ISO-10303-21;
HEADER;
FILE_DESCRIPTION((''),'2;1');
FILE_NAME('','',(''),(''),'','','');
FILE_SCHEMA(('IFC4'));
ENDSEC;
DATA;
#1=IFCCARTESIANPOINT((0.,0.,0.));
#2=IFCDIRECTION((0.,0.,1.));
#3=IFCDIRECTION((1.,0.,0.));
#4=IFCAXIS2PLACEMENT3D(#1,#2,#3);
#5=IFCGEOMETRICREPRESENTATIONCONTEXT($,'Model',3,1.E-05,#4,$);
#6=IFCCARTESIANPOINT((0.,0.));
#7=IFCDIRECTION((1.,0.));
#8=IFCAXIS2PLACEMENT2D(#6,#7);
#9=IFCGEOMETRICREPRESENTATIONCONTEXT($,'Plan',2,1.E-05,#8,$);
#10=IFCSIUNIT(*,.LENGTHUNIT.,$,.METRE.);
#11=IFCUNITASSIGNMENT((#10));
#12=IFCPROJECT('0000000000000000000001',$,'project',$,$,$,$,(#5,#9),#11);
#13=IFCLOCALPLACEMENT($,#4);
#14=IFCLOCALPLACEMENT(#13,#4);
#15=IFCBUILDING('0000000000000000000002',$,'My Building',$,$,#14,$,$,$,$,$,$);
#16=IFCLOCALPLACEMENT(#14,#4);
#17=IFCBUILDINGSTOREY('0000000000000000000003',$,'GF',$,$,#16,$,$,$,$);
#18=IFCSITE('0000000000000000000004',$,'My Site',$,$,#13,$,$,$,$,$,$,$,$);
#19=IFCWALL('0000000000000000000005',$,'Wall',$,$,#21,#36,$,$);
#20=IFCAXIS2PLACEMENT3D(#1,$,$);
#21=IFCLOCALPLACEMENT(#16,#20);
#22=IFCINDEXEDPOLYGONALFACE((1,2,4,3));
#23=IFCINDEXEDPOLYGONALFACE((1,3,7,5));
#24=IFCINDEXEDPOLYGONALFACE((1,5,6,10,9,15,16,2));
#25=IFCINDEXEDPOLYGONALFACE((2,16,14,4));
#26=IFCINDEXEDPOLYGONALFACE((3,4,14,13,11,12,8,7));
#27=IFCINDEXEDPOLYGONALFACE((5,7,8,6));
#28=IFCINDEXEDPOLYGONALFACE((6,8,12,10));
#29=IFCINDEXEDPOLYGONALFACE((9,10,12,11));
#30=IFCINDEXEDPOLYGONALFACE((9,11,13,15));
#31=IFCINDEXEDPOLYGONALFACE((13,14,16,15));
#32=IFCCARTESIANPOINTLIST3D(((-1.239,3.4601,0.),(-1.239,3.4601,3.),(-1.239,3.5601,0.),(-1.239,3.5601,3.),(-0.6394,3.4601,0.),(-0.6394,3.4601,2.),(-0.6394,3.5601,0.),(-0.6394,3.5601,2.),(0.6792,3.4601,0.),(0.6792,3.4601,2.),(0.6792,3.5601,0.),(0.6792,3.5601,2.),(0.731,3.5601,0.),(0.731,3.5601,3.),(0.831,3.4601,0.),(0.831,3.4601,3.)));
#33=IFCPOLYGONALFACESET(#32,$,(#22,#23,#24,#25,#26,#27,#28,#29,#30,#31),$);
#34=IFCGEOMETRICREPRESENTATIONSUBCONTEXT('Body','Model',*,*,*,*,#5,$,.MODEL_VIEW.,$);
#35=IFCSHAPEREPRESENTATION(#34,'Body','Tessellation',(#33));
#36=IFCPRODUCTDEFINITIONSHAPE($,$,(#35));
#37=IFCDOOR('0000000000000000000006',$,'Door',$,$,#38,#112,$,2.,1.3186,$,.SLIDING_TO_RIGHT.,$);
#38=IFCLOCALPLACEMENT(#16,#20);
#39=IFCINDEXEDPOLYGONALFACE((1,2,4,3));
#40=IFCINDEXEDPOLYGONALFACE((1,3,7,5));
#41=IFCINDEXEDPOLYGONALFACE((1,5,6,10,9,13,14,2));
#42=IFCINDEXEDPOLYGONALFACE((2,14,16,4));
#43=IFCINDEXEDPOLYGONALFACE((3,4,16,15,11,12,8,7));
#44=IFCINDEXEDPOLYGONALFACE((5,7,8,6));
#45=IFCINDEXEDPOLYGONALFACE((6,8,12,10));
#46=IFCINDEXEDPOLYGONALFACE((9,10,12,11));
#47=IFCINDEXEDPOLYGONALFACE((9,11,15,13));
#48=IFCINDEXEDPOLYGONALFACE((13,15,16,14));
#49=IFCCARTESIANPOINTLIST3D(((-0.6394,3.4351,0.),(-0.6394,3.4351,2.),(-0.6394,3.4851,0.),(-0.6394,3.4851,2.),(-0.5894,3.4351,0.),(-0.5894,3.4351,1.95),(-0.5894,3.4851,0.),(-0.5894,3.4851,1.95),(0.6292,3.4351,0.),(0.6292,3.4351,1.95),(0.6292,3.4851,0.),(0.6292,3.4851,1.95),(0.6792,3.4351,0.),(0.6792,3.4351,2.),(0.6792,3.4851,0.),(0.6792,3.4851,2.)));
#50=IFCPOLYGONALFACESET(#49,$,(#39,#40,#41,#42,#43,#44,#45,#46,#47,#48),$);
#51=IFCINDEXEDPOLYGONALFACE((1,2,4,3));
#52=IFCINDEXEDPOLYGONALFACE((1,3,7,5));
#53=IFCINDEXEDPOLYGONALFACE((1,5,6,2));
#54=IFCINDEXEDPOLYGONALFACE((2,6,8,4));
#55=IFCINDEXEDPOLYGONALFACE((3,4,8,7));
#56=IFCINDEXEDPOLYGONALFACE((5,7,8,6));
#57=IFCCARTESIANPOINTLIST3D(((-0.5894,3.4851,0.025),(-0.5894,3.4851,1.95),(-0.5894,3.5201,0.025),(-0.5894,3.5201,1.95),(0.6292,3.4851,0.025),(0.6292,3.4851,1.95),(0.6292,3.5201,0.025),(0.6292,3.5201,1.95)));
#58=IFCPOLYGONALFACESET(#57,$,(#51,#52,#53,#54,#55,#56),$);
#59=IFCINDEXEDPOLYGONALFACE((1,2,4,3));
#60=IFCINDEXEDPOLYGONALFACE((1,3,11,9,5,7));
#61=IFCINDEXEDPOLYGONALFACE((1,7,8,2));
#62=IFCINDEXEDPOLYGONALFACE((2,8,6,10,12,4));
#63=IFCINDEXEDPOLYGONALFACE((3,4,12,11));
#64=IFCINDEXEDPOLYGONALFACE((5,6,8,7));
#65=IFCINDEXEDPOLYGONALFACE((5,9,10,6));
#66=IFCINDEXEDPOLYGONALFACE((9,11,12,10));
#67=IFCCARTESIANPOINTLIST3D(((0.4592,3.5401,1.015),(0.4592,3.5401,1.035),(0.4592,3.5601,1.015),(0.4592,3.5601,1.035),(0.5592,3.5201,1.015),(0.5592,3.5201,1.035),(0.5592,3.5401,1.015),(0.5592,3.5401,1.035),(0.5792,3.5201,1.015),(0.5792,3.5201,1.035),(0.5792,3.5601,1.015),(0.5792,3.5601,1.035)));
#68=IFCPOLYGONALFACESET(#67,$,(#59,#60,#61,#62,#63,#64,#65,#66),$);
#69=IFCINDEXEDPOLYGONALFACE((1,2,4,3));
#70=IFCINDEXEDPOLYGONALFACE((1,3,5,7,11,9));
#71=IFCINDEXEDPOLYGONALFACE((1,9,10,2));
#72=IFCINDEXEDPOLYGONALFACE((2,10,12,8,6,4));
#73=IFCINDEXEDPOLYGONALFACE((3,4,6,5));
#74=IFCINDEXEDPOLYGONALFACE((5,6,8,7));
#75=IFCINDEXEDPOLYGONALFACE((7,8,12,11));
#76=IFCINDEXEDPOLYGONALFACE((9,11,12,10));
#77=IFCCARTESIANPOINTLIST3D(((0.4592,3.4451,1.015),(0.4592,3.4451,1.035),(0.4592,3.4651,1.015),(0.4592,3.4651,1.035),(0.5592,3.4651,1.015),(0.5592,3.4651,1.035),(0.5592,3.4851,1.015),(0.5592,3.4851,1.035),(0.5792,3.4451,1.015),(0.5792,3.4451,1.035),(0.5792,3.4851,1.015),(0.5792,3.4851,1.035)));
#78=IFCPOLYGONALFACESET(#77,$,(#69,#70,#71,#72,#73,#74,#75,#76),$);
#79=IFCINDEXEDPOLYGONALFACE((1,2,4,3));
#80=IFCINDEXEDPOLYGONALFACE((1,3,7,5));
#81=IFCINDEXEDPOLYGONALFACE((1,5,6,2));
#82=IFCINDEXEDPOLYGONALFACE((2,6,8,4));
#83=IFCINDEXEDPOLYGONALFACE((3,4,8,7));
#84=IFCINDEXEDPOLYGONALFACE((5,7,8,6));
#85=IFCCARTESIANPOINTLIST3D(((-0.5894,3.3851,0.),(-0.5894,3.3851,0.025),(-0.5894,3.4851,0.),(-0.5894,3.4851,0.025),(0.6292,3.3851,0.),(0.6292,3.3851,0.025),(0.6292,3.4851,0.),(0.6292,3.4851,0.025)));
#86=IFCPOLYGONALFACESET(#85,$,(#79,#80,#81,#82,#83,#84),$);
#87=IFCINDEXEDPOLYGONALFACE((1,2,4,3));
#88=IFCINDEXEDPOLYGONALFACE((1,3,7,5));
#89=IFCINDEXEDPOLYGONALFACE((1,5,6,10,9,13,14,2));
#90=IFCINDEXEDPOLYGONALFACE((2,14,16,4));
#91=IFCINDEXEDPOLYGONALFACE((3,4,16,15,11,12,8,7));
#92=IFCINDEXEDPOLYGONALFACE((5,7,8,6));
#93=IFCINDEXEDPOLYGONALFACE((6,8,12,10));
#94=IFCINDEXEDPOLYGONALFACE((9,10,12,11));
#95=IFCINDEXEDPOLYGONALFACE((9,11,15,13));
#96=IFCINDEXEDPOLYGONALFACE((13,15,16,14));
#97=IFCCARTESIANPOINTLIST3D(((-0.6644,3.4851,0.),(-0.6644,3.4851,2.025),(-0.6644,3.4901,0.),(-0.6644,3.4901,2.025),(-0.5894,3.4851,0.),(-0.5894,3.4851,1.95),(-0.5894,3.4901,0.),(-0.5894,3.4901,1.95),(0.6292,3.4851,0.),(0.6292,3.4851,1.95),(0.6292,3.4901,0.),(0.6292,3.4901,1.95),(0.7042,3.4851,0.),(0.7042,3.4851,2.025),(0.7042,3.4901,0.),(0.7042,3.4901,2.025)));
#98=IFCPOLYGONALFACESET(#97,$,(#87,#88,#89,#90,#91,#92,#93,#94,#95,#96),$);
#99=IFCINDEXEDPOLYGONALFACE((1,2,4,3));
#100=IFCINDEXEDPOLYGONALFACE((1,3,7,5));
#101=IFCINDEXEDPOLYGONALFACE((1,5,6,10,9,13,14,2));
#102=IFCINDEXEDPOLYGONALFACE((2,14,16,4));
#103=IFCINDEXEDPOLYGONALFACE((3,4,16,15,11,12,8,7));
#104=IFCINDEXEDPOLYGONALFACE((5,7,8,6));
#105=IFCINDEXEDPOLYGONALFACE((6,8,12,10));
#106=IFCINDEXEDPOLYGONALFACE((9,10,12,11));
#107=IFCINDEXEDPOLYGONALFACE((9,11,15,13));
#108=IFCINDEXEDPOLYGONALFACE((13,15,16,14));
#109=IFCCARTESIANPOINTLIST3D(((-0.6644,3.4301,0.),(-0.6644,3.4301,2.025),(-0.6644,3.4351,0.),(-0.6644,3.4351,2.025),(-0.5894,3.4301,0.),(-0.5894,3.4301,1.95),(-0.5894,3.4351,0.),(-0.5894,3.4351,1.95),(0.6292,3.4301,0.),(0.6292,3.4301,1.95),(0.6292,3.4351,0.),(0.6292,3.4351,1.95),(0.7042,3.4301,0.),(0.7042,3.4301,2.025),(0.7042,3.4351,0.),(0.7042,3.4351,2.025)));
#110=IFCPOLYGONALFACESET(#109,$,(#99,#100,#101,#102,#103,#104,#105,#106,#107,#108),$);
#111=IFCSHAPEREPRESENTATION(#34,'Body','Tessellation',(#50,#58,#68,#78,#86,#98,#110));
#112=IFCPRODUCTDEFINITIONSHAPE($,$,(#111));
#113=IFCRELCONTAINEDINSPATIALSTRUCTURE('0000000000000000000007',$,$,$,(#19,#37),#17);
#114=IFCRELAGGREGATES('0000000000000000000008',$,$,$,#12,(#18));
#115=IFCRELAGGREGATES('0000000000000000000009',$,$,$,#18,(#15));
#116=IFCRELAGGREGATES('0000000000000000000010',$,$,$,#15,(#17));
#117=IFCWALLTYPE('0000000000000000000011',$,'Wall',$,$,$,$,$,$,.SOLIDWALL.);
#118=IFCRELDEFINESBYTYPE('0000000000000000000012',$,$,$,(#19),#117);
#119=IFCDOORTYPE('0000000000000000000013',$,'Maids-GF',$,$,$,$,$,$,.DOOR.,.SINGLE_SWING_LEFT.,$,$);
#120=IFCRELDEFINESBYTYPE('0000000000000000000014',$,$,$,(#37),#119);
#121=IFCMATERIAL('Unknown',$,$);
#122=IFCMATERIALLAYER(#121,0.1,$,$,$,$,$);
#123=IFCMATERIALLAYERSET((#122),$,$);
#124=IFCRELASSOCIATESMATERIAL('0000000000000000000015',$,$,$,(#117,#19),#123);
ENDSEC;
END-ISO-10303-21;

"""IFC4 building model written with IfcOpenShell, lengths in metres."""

from ifc_helpers import new_model, entity, si_unit, frame, origin_with_axes, origin_2d_with_axis, place, context, subcontext, project, spatial, line, indexed_curve, outline, extrude, shape, source, transform, mapped, material, layer, layer_set, layer_usage, type_object, type_shapes, element, fill, save


model = new_model("IFC4")

# Units and contexts
model_context = context("Model", 3, precision=1e-05, world=origin_with_axes())
plan_context = context("Plan", 2, precision=1e-05, world=origin_2d_with_axis())
body_context_1 = subcontext(model_context, "Body", "Model", "MODEL_VIEW")
body_context_2 = subcontext(plan_context, "Body", "Plan", "PLAN_VIEW")
ifc_project = project(units=[si_unit("LENGTHUNIT", "METRE")], contexts=[model_context, plan_context])

# Site, building, storey
site_placement = place(None, origin_with_axes())
site = spatial("IfcSite", under=ifc_project, at=site_placement, Name="My Site")
building_placement = place(site_placement, origin_with_axes())
building = spatial("IfcBuilding", under=site, at=building_placement, Name="My Building")
storey_placement = place(building_placement, origin_with_axes())
storey = spatial("IfcBuildingStorey", under=building, at=storey_placement, Name="GF")

# Shared definitions
ifc_material_1 = material(Name="Unknown")

# Shared definitions
ifc_layer_1 = layer(ifc_material_1, 0.1)
ifc_layer_set_1 = layer_set([ifc_layer_1])
wall_type = type_object("IfcWallType", Name="Wall", PredefinedType="SOLIDWALL", material=ifc_layer_set_1)

# Wall, opening, door
ifc_layer_usage_1 = layer_usage(ifc_layer_set_1, "AXIS2", "POSITIVE", 0.0)
wall_1_placement = place(storey_placement, frame((0.731, 3.5601, 0.0), z_axis=(0.0, 0.0, 1.0), x_axis=(-1.0, 0.0, 0.0)))
wall_1 = element("IfcWall", 1, at=wall_1_placement, inside=storey, type_object=wall_type, material=ifc_layer_usage_1, Name="Wall", context=body_context_1, shape_type="SweptSolid", body=[
    extrude(outline(indexed_curve([(0.0, 0.0), (-0.1, 0.1), (1.97, 0.1), (1.97, 0.0)], segments=[line(1, 2, 3, 4, 1)])), origin_with_axes(), (0.0, 0.0, 1.0), 3.0),
])
shared_shape_1 = source(origin_with_axes(), body_context_1, "Body", "SweptSolid", [
    extrude(outline(indexed_curve([(0.0, 0.0), (1.3186, 0.0), (1.3186, 2.0), (0.0, 2.0)], segments=[line(1, 2, 3, 4, 1)])), frame((0.0, -0.6, 0.0), z_axis=(0.0, -1.0, 0.0), x_axis=(1.0, 0.0, 0.0)), (0.0, 0.0, -1.0), 1.2),
])
opening_1_placement = place(wall_1_placement, frame((0.0518, 0.075, 0.0), z_axis=(0.0, 0.0, 1.0), x_axis=(1.0, 0.0, 0.0)))
opening_1 = element("IfcOpeningElement", 2, at=opening_1_placement, cuts=wall_1, PredefinedType="OPENING", context=body_context_1, shape_type="MappedRepresentation", body=[
    mapped(shared_shape_1, transform((0.0, 0.0, 0.0), x_axis=(1.0, 0.0, 0.0), y_axis=(0.0, 1.0, 0.0), z_axis=(0.0, 0.0, 1.0), scale=1.0)),
])
door_type_1 = type_object("IfcDoorType", Name="Maids-GF", OperationType="SINGLE_SWING_LEFT", PredefinedType="DOOR")
shared_shape_2 = source(origin_with_axes(), body_context_1, "Body", "SweptSolid", [
    extrude(outline(indexed_curve([(0.0, 0.0), (0.0, 2.0), (1.3186, 2.0), (1.3186, 0.0), (1.2686, 0.0), (1.2686, 1.95), (0.05, 1.95), (0.05, 0.0)], segments=[line(1, 2, 3, 4, 5, 6, 7, 8, 1)])), frame((0.0, 0.0, 0.0), z_axis=(0.0, -1.0, 0.0), x_axis=(1.0, 0.0, 0.0)), (0.0, 0.0, -1.0), 0.05),
    extrude(outline(indexed_curve([(0.0, 0.0), (1.2186, 0.0), (1.2186, 0.035), (0.0, 0.035)], segments=[line(1, 2, 3, 4, 1)])), frame((0.05, -0.035, 0.025), z_axis=(0.0, 0.0, 1.0), x_axis=(1.0, 0.0, 0.0)), (0.0, 0.0, 1.0), 1.925),
    extrude(outline(indexed_curve([(0.0, 0.0), (0.0, -0.04), (0.12, -0.04), (0.12, -0.02), (0.02, -0.02), (0.02, 0.0)], segments=[line(1, 2, 3, 4, 5, 6, 1)])), frame((0.1, -0.035, 1.015), z_axis=(0.0, 0.0, 1.0), x_axis=(1.0, 0.0, 0.0)), (0.0, 0.0, 1.0), 0.02),
    extrude(outline(indexed_curve([(0.0, 0.0), (0.0, 0.04), (0.12, 0.04), (0.12, 0.02), (0.02, 0.02), (0.02, 0.0)], segments=[line(1, 2, 3, 4, 5, 6, 1)])), frame((0.1, 0.0, 1.015), z_axis=(0.0, 0.0, 1.0), x_axis=(1.0, 0.0, 0.0)), (0.0, 0.0, 1.0), 0.02),
    extrude(outline(indexed_curve([(0.0, 0.0), (1.2186, 0.0), (1.2186, 0.1), (0.0, 0.1)], segments=[line(1, 2, 3, 4, 1)])), frame((0.05, 0.0, 0.0), z_axis=(0.0, 0.0, 1.0), x_axis=(1.0, 0.0, 0.0)), (0.0, 0.0, 1.0), 0.025),
    extrude(outline(indexed_curve([(0.0, 0.0), (0.0, 2.025), (1.3686, 2.025), (1.3686, 0.0), (1.2936, 0.0), (1.2936, 1.95), (0.075, 1.95), (0.075, 0.0)], segments=[line(1, 2, 3, 4, 5, 6, 7, 8, 1)])), frame((-0.025, -0.005, 0.0), z_axis=(0.0, -1.0, 0.0), x_axis=(1.0, 0.0, 0.0)), (0.0, 0.0, -1.0), 0.005),
    extrude(outline(indexed_curve([(0.0, 0.0), (0.0, 2.025), (1.3686, 2.025), (1.3686, 0.0), (1.2936, 0.0), (1.2936, 1.95), (0.075, 1.95), (0.075, 0.0)], segments=[line(1, 2, 3, 4, 5, 6, 7, 8, 1)])), frame((-0.025, 0.05, 0.0), z_axis=(0.0, -1.0, 0.0), x_axis=(1.0, 0.0, 0.0)), (0.0, 0.0, -1.0), 0.005),
])
shared_shape_3 = source(origin_with_axes(), body_context_2, "Body", "Curve2D", [
    entity("IfcIndexedPolyCurve", entity("IfcCartesianPointList2D", [[0.0, 0.0], [0.05, 0.0], [0.05, 0.05], [0.0, 0.05]]), [entity("IfcLineIndex", [1, 2, 3, 4, 1])]),
    entity("IfcIndexedPolyCurve", entity("IfcCartesianPointList2D", [[1.3186, 0.0], [1.2686, 0.0], [1.2686, 0.05], [1.3186, 0.05]]), [entity("IfcLineIndex", [1, 2, 3, 4, 1])]),
    entity("IfcIndexedPolyCurve", entity("IfcCartesianPointList2D", [[1.8779, -0.035], [0.6593, -0.035], [0.6593, 0.0], [1.8779, 0.0]]), [entity("IfcLineIndex", [1, 2, 3, 4, 1])]),
])
type_shapes(door_type_1, [shared_shape_2, shared_shape_3])
door_1_placement = place(opening_1_placement, frame((0.0, 0.0, 0.0), z_axis=(0.0, 0.0, 1.0), x_axis=(1.0, 0.0, 0.0)))
door_1 = element("IfcDoor", 3, at=door_1_placement, inside=storey, type_object=door_type_1, Name="Door", OperationType="SLIDING_TO_RIGHT", OverallHeight=2.0, OverallWidth=1.3186, shapes=[
    shape(body_context_1, "Body", "MappedRepresentation", [mapped(shared_shape_2, transform((0.0, 0.0, 0.0), x_axis=(1.0, 0.0, 0.0), y_axis=(0.0, 1.0, 0.0), z_axis=(0.0, 0.0, 1.0), scale=1.0))]),
    shape(body_context_2, "Body", "MappedRepresentation", [mapped(shared_shape_3, transform((0.0, 0.0, 0.0), x_axis=(1.0, 0.0, 0.0), y_axis=(0.0, 1.0, 0.0), z_axis=(0.0, 0.0, 1.0), scale=1.0))]),
])
fill(opening_1, door_1)

save(model, "model.ifc")
